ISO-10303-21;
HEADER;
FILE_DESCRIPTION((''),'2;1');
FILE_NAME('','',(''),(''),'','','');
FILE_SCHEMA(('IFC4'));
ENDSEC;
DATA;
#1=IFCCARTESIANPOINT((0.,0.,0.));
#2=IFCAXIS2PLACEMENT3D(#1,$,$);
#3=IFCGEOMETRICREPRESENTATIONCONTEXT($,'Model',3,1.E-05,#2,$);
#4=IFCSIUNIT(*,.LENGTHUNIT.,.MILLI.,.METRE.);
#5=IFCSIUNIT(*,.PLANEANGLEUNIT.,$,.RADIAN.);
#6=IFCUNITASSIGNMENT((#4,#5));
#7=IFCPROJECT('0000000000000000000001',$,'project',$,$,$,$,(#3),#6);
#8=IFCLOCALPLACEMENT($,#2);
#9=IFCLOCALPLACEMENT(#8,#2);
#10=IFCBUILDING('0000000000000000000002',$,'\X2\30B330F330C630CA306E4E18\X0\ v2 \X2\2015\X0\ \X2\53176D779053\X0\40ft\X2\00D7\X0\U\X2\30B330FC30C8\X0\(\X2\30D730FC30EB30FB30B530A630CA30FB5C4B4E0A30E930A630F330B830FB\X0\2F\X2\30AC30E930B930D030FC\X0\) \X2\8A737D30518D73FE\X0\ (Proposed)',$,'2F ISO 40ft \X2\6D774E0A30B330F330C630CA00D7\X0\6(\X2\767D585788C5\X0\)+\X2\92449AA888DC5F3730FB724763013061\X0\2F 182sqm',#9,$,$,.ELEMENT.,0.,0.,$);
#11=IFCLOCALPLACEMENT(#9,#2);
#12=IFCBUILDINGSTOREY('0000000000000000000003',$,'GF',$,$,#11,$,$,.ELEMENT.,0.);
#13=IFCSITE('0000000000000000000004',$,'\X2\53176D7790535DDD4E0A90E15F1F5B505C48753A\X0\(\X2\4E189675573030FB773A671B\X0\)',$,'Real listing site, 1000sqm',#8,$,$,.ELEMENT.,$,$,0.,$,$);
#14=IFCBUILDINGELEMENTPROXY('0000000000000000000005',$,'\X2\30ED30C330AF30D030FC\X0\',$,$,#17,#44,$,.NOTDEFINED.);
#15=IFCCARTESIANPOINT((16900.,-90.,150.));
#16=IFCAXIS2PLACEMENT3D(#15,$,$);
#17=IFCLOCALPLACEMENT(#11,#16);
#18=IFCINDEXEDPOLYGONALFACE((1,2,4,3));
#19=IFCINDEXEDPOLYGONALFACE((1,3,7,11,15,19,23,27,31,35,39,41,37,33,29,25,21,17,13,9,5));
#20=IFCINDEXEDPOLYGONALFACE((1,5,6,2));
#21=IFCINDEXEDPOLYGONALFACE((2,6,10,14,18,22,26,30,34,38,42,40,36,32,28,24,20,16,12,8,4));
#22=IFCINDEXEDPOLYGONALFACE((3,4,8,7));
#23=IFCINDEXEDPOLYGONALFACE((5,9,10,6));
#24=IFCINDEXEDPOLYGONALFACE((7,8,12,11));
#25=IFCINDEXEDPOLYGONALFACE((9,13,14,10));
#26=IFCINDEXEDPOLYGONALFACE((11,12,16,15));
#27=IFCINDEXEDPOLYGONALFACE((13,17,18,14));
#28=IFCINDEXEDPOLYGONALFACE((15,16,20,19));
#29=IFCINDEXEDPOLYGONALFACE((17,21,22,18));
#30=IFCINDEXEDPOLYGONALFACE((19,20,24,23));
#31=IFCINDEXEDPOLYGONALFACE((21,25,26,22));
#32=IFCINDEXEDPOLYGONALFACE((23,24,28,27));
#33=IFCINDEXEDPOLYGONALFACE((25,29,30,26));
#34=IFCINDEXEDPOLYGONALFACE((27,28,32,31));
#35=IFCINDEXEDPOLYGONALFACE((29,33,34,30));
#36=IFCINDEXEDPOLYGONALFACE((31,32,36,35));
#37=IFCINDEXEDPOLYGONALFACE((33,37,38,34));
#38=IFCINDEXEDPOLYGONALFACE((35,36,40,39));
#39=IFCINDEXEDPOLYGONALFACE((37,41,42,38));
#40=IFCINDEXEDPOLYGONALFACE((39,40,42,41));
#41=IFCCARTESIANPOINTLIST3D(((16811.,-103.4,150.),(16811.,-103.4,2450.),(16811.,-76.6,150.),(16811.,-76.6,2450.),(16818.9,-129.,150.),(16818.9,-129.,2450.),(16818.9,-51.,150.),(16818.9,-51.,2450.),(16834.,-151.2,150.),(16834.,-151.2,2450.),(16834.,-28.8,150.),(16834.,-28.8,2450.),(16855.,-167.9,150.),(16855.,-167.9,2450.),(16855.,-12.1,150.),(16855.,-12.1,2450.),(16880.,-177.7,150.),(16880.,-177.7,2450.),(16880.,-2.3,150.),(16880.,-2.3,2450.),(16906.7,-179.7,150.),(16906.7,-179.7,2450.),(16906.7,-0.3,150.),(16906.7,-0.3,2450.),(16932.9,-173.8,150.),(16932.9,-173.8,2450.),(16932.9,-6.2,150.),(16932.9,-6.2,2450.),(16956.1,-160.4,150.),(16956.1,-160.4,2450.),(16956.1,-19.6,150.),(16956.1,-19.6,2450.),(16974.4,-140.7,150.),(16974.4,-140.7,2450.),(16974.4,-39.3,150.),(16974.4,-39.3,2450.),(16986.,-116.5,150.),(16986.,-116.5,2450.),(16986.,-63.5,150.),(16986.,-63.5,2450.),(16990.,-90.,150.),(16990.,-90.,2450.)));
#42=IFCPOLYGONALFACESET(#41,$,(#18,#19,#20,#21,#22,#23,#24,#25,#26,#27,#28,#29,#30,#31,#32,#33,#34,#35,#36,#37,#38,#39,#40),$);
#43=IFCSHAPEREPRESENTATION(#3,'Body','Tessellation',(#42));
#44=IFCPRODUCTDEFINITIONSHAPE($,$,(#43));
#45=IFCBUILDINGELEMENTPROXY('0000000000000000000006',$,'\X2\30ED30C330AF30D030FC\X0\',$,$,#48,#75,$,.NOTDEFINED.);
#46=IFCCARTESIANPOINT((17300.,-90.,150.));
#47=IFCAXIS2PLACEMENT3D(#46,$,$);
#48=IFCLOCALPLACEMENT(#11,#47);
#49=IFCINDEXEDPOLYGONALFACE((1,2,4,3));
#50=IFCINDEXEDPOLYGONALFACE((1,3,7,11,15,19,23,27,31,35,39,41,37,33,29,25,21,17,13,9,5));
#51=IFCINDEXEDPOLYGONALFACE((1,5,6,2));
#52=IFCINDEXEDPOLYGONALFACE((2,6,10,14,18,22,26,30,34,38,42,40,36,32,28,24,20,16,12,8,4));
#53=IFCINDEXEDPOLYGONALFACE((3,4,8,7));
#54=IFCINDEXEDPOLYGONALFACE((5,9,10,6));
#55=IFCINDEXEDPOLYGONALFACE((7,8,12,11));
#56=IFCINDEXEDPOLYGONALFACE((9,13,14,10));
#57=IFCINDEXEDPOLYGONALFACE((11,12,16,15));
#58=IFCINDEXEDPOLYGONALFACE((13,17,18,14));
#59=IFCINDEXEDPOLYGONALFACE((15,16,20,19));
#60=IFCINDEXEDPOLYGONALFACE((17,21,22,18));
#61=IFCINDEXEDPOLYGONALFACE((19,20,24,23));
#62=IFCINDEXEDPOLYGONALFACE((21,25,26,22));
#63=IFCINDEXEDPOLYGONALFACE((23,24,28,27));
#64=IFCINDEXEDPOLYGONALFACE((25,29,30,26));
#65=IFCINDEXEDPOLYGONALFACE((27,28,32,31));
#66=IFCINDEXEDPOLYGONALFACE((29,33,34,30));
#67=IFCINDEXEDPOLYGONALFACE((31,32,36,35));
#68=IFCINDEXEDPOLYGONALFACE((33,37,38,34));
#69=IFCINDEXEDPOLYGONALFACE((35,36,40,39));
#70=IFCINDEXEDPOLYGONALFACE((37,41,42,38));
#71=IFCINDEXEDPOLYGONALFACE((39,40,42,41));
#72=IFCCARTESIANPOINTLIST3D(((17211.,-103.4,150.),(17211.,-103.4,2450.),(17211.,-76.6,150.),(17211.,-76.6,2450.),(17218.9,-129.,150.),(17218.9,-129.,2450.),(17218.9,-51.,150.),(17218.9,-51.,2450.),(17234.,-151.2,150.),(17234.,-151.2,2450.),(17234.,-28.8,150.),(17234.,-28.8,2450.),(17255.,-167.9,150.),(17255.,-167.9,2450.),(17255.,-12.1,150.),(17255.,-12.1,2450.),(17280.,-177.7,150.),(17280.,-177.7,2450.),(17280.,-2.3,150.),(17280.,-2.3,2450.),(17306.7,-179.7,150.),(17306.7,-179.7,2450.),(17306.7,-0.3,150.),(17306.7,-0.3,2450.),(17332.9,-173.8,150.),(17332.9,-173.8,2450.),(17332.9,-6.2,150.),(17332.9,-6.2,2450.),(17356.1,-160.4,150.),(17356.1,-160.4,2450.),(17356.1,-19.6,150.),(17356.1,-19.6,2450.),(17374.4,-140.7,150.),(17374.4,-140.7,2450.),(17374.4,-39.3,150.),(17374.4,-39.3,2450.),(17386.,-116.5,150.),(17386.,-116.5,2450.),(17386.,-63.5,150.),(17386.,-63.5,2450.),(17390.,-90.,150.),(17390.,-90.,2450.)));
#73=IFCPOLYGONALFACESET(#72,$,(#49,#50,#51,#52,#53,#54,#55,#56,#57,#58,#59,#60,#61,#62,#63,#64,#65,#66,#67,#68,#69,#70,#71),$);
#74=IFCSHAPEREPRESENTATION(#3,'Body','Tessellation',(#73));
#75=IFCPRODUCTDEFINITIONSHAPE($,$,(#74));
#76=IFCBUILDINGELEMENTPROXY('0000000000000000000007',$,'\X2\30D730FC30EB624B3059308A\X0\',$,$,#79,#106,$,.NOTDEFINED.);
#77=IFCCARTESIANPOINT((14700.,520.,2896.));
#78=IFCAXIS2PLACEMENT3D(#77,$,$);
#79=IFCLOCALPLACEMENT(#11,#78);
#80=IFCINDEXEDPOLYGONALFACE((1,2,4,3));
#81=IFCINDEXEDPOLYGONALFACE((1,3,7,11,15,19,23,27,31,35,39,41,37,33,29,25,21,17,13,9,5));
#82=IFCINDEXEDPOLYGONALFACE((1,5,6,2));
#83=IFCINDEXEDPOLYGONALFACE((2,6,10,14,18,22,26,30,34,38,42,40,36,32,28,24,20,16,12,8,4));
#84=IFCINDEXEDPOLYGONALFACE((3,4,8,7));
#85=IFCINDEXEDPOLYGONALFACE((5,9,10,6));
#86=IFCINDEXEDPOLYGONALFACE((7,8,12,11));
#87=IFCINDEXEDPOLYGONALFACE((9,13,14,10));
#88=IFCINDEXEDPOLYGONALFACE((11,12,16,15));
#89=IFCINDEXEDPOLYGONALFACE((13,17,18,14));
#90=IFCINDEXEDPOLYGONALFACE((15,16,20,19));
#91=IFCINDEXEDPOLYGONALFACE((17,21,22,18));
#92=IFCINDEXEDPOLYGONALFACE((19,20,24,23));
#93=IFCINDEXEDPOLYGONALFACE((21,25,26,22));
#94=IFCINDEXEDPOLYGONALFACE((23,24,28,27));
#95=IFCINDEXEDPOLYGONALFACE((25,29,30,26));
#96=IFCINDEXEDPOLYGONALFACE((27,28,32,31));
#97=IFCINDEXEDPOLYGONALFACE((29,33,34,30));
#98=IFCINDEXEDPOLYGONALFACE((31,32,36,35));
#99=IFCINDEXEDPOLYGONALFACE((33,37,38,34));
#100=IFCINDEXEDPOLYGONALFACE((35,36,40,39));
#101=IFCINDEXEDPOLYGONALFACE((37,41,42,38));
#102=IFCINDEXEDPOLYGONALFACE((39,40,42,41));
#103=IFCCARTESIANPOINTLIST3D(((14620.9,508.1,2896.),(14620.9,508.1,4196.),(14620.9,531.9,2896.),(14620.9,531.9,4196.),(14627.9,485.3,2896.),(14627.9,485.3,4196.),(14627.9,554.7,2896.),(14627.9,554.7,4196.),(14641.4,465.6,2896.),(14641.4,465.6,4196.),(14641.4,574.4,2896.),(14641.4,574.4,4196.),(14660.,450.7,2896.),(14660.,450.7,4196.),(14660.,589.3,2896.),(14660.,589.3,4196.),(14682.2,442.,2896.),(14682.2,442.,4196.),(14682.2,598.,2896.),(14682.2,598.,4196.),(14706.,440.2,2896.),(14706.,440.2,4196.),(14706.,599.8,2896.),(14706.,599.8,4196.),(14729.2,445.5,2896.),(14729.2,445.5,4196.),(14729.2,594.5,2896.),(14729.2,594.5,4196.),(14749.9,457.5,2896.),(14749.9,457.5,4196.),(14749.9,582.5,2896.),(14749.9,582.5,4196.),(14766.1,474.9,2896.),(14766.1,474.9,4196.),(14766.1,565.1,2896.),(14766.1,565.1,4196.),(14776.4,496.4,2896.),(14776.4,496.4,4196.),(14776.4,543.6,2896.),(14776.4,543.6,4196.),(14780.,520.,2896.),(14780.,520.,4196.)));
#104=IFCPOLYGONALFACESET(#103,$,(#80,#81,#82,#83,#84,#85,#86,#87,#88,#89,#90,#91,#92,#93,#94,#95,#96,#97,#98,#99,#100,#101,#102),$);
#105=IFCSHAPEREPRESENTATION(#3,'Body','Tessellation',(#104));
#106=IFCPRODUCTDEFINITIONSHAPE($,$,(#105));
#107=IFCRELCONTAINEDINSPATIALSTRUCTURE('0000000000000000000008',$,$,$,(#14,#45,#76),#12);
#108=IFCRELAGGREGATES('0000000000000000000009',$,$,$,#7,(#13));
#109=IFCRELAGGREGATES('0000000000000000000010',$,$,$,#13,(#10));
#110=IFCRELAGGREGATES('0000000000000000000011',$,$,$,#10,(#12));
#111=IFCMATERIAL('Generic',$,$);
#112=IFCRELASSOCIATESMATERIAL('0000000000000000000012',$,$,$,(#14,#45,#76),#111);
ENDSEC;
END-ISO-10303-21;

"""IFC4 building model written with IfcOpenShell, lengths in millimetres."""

from ifc_helpers import new_model, si_unit, frame, origin, origin_2d, place, context, project, spatial, circle, extrude, material, element, save


model = new_model("IFC4")

# Units and contexts
model_context = context("Model", 3, precision=1e-05, world=origin())
ifc_project = project(units=[si_unit("LENGTHUNIT", "METRE", prefix="MILLI"), si_unit("PLANEANGLEUNIT", "RADIAN")], contexts=[model_context])

# Site, building, storey
site_placement = place(None, origin())
site = spatial("IfcSite", under=ifc_project, at=site_placement, Name="北海道川上郡弟子屈町(丘陵地・眺望)", ObjectType="Real listing site, 1000sqm", CompositionType="ELEMENT", RefElevation=0.0)
building_placement = place(site_placement, origin())
building = spatial("IfcBuilding", under=site, at=building_placement, Name="コンテナの丘 v2 ― 北海道40ft×Uコート(プール・サウナ・屋上ラウンジ・2Fガラスバー) 詳細再現 (Proposed)", ObjectType="2F ISO 40ft 海上コンテナ×6(白塗装)+鉄骨補強・片持ち2F 182sqm", CompositionType="ELEMENT", ElevationOfRefHeight=0.0, ElevationOfTerrain=0.0)
storey_placement = place(building_placement, origin())
storey = spatial("IfcBuildingStorey", under=building, at=storey_placement, Name="GF", CompositionType="ELEMENT", Elevation=0.0)

# Shared definitions
ifc_material = material(Name="Generic")

# Building element proxies
proxy_1_placement = place(storey_placement, frame((16900.0, -90.0, 150.0)))
element("IfcBuildingElementProxy", 1, at=proxy_1_placement, inside=storey, material=ifc_material, Name="ロックバー", PredefinedType="NOTDEFINED", context=model_context, shape_type="SweptSolid", body=[
    extrude(circle(Radius=90.0, at=origin_2d()), frame((16900.0, -90.0, 150.0)), (0.0, 0.0, 1.0), 2300.0),
])
proxy_2_placement = place(storey_placement, frame((17300.0, -90.0, 150.0)))
element("IfcBuildingElementProxy", 2, at=proxy_2_placement, inside=storey, material=ifc_material, Name="ロックバー", PredefinedType="NOTDEFINED", context=model_context, shape_type="SweptSolid", body=[
    extrude(circle(Radius=90.0, at=origin_2d()), frame((17300.0, -90.0, 150.0)), (0.0, 0.0, 1.0), 2300.0),
])
proxy_3_placement = place(storey_placement, frame((14700.0, 520.0, 2896.0)))
element("IfcBuildingElementProxy", 3, at=proxy_3_placement, inside=storey, material=ifc_material, Name="プール手すり", PredefinedType="NOTDEFINED", context=model_context, shape_type="SweptSolid", body=[
    extrude(circle(Radius=80.0, at=origin_2d()), frame((14700.0, 520.0, 2896.0)), (0.0, 0.0, 1.0), 1300.0),
])

save(model, "model.ifc")
